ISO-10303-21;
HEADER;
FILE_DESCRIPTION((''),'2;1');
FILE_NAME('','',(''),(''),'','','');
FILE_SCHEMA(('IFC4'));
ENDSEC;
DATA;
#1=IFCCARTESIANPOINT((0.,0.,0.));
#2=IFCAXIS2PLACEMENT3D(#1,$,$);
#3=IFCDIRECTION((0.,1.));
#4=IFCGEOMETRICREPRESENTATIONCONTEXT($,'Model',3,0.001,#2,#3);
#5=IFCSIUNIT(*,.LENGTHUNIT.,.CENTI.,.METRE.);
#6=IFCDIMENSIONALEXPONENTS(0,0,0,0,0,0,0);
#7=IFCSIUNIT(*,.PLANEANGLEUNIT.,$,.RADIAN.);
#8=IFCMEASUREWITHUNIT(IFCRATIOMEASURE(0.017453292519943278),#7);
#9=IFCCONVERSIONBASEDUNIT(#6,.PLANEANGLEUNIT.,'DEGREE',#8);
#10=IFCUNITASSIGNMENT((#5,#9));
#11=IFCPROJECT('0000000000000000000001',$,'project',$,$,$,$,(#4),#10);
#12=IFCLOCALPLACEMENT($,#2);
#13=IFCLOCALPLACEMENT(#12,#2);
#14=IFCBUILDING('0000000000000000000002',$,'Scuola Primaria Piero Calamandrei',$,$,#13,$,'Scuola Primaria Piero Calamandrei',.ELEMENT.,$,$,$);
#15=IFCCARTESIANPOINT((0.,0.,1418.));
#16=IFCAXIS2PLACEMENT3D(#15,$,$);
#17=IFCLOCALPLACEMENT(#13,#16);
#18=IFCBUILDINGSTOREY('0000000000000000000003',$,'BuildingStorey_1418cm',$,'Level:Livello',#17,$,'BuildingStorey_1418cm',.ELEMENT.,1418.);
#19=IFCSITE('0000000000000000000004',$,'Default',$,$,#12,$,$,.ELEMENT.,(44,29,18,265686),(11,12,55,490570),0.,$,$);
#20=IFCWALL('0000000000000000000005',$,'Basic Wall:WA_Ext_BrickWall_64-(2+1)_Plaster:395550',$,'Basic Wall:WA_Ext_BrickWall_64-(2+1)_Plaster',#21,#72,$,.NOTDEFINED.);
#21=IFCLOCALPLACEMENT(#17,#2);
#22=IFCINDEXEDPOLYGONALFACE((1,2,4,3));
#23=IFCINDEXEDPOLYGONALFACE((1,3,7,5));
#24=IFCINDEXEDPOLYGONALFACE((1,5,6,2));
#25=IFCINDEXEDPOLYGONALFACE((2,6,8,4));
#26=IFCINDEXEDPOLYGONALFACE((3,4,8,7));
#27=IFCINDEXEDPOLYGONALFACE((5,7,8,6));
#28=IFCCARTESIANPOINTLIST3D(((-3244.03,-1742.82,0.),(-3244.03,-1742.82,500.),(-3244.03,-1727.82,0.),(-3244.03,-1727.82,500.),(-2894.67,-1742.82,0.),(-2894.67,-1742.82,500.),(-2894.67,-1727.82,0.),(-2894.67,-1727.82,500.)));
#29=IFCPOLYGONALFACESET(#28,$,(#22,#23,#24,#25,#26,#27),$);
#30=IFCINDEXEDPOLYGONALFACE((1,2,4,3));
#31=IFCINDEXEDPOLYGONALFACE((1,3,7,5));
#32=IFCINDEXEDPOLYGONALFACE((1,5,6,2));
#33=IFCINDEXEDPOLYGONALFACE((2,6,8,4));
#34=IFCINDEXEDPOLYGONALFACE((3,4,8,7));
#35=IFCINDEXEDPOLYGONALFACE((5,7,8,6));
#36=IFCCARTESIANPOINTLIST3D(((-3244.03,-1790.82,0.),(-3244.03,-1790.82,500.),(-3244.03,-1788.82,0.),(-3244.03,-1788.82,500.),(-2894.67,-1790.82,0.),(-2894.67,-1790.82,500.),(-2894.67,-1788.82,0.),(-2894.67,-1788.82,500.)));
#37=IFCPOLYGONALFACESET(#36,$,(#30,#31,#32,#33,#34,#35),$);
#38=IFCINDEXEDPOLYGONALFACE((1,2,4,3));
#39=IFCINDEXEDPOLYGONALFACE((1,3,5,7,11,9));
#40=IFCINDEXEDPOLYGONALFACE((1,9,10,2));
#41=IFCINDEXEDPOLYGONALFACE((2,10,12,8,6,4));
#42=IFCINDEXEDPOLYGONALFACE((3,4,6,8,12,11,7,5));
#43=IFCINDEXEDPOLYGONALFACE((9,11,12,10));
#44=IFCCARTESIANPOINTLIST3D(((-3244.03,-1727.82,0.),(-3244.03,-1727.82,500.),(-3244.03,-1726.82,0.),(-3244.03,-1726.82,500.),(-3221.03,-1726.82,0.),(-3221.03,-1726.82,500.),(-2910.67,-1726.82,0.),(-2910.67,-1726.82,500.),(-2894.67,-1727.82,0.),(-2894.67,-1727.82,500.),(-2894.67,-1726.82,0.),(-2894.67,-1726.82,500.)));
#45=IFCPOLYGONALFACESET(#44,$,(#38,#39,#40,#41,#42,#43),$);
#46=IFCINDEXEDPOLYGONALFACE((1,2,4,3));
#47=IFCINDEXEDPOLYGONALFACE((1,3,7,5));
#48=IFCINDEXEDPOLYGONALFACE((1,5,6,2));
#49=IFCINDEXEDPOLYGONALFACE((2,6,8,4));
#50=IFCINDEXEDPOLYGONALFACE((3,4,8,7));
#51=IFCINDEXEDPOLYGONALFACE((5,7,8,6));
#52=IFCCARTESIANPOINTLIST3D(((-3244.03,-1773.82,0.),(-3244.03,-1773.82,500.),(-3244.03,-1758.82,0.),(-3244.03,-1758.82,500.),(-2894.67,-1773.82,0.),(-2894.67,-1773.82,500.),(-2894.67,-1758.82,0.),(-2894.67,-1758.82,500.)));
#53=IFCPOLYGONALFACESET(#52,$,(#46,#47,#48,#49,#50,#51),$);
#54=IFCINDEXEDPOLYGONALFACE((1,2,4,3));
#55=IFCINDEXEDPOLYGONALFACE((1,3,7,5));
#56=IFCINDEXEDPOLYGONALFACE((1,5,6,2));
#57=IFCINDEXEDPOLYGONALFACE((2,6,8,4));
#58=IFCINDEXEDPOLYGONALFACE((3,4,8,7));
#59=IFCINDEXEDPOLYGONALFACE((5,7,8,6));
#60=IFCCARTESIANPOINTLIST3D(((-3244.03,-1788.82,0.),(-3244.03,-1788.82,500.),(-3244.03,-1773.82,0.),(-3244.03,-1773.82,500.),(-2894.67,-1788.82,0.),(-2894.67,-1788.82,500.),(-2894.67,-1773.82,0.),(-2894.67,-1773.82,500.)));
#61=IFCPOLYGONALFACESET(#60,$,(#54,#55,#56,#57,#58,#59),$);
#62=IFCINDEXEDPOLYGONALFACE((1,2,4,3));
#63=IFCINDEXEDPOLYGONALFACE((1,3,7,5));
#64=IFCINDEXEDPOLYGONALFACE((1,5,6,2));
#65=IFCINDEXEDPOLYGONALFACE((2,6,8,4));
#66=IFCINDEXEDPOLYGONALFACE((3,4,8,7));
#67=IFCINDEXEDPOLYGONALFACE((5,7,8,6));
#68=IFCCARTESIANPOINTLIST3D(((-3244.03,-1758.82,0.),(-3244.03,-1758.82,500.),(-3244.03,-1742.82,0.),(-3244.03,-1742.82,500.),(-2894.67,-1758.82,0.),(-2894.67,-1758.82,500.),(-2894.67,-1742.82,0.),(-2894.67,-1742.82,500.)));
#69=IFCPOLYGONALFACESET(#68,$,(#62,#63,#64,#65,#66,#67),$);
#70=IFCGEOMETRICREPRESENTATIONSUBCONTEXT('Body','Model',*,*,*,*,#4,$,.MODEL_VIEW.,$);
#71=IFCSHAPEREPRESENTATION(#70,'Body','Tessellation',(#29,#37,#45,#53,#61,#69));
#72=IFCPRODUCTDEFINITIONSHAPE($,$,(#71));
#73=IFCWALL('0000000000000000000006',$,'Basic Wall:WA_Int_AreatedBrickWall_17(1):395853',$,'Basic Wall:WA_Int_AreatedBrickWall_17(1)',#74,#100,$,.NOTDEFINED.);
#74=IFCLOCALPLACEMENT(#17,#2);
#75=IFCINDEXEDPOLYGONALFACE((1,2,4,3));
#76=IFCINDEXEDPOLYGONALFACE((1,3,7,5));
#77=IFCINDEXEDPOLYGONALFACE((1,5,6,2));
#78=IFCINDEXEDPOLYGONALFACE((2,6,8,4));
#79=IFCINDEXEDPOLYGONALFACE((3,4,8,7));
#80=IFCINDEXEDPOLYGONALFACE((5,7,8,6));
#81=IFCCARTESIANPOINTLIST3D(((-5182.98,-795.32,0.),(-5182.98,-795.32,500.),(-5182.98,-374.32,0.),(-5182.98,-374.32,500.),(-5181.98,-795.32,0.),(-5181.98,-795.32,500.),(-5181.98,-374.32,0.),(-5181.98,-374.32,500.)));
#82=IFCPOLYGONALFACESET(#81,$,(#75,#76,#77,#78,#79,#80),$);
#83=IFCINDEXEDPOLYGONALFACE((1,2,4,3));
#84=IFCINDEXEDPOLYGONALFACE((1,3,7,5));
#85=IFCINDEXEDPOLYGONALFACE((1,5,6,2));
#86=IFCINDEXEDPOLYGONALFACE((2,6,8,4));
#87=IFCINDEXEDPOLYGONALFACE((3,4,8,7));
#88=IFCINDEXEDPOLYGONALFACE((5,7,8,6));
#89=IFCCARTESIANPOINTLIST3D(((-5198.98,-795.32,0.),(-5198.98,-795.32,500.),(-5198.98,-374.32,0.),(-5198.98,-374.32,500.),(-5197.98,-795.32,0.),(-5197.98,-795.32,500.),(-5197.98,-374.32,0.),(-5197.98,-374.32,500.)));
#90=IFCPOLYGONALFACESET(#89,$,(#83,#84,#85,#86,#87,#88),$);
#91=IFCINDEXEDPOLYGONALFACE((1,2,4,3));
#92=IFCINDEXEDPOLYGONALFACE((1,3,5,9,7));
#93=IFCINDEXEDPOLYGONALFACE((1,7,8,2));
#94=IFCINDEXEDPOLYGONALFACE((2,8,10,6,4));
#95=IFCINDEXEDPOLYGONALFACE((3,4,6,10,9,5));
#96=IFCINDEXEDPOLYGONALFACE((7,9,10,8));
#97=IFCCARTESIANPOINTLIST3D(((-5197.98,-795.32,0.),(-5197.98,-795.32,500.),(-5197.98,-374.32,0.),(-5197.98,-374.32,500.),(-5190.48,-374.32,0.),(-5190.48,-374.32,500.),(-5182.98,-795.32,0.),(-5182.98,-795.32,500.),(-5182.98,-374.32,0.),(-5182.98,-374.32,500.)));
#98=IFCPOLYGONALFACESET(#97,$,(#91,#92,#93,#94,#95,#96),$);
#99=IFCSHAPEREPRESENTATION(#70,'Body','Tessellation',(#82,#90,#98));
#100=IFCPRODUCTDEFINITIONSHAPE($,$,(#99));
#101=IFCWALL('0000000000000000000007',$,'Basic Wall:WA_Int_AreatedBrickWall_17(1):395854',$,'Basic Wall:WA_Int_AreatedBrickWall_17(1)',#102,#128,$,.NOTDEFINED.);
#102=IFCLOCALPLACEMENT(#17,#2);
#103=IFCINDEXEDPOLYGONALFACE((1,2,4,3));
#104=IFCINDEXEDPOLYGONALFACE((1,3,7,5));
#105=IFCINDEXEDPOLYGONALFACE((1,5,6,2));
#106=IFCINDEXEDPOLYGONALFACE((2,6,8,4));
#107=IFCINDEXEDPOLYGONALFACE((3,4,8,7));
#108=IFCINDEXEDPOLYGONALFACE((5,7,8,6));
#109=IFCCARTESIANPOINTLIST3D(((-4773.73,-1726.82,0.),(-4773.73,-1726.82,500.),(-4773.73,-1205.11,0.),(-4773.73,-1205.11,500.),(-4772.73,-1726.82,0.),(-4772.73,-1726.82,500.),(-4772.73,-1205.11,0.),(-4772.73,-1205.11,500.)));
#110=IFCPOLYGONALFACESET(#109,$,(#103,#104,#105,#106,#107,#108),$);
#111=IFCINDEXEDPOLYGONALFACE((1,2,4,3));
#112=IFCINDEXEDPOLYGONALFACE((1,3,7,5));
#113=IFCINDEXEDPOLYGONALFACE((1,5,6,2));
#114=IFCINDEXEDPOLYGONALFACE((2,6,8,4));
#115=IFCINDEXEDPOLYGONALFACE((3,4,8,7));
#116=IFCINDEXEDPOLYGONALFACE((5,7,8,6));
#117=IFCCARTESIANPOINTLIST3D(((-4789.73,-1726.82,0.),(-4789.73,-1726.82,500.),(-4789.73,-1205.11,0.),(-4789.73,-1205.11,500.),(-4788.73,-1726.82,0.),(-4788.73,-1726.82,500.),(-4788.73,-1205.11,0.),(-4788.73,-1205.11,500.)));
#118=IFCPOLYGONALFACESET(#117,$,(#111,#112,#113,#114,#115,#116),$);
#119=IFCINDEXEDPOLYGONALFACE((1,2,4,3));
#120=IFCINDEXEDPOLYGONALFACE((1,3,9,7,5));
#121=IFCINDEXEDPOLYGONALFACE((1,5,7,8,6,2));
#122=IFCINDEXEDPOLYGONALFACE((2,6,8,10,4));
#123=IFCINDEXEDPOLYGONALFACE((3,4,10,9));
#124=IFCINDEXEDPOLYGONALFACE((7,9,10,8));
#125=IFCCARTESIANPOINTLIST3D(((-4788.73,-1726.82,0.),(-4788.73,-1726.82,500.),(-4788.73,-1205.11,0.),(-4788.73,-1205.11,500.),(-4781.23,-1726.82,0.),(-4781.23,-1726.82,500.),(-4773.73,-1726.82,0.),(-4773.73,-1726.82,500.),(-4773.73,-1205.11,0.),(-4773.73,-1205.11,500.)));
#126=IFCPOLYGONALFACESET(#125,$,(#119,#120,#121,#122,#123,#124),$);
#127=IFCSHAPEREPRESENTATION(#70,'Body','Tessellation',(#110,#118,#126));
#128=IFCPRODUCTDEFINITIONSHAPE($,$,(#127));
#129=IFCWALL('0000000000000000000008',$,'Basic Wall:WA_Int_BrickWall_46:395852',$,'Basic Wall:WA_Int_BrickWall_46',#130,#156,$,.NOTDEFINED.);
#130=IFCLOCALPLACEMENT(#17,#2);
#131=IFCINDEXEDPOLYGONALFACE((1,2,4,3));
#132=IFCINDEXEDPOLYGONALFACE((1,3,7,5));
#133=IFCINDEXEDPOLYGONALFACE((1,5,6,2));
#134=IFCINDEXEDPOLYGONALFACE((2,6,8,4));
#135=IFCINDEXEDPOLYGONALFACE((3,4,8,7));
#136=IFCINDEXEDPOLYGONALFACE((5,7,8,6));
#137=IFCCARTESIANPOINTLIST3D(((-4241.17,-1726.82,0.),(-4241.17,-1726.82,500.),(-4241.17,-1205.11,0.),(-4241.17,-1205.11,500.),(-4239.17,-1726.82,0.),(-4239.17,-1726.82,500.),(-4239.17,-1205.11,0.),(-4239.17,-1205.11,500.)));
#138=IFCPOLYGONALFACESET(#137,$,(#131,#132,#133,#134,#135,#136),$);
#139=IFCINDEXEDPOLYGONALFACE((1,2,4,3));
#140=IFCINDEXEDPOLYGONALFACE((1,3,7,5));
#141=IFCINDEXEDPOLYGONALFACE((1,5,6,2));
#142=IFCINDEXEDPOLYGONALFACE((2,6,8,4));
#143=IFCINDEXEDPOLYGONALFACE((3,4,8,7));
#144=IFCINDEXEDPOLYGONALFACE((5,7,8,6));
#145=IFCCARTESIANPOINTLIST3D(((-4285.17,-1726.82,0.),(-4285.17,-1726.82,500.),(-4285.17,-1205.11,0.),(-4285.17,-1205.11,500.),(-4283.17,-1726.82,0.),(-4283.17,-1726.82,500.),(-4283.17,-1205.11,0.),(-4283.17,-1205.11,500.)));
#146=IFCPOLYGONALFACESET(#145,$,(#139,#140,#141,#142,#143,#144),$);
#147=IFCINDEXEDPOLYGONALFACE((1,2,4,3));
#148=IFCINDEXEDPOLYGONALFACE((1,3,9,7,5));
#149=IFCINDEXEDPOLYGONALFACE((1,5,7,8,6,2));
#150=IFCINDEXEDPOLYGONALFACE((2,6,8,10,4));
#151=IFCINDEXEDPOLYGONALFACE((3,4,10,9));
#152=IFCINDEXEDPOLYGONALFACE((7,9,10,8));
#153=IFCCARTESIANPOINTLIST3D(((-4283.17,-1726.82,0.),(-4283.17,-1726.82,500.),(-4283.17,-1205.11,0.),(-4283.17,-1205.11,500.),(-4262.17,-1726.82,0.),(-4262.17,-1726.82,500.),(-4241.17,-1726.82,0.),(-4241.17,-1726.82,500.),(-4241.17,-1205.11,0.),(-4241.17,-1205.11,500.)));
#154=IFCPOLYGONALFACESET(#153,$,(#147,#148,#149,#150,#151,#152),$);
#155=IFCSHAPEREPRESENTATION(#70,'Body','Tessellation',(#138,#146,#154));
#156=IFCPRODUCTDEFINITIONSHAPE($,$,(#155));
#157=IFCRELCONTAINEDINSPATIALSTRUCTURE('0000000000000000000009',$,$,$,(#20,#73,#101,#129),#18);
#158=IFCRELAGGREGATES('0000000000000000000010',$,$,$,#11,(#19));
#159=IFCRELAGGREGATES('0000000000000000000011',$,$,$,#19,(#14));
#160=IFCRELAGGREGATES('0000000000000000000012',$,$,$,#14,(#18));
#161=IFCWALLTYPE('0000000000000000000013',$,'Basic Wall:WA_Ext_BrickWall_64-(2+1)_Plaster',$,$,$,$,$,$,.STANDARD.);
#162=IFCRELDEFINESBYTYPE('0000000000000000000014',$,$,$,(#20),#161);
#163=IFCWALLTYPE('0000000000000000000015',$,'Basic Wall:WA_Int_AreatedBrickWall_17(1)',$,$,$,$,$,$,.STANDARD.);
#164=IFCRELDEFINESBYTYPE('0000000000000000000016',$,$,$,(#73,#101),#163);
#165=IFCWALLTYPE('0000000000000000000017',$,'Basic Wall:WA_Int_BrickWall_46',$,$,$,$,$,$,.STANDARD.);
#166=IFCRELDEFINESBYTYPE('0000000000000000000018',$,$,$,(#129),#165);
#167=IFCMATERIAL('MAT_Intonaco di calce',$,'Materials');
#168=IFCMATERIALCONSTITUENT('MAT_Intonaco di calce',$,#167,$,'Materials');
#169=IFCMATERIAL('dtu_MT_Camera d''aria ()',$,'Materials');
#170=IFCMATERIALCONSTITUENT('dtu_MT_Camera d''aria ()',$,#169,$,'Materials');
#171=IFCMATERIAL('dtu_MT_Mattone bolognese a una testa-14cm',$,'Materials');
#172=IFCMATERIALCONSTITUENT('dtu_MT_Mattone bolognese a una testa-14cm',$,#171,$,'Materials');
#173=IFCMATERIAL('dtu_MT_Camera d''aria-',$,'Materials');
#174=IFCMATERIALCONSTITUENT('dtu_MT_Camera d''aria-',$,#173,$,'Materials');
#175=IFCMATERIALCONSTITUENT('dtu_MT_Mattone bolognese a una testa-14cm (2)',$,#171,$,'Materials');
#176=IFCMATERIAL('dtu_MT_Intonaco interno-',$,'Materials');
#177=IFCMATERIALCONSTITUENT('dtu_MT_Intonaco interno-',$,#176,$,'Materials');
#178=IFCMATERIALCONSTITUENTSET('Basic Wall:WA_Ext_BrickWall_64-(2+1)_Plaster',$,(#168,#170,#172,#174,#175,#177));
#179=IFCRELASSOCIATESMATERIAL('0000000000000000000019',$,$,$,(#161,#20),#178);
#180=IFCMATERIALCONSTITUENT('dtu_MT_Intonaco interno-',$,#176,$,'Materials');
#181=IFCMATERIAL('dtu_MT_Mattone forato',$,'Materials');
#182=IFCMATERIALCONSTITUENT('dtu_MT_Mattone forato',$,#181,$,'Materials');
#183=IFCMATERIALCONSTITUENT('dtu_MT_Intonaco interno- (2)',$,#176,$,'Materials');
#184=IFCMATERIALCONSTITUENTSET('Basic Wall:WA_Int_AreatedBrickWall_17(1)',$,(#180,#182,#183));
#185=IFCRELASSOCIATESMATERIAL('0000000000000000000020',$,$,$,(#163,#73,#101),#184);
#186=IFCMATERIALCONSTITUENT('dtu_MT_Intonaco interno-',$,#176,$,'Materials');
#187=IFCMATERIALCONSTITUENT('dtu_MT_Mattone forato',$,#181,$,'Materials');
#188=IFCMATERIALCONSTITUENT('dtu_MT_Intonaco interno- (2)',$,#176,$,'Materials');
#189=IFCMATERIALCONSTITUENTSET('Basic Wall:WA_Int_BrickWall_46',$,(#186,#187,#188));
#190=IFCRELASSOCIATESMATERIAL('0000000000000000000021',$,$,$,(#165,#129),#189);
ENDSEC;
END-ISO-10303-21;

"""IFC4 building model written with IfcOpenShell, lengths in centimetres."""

from ifc_helpers import new_model, entity, si_unit, converted_unit, direction, frame, origin, place, context, subcontext, project, spatial, indexed_curve, outline, extrude, material, constituent, constituent_set, type_object, element, save


model = new_model("IFC4")

# Units and contexts
model_context = context("Model", 3, precision=0.001, world=origin(), true_north=direction((0.0, 1.0)))
body_context = subcontext(model_context, "Body", "Model", "MODEL_VIEW")
ifc_project = project(units=[si_unit("LENGTHUNIT", "METRE", prefix="CENTI"), converted_unit("PLANEANGLEUNIT", "DEGREE", entity("IfcRatioMeasure", 0.017453292519943278), si_unit("PLANEANGLEUNIT", "RADIAN"), dimensions=[0, 0, 0, 0, 0, 0, 0])], contexts=[model_context])

# Site, building, storey
site_placement = place(None, origin())
site = spatial("IfcSite", under=ifc_project, at=site_placement, Name="Default", CompositionType="ELEMENT", RefLatitude=(44, 29, 18, 265686), RefLongitude=(11, 12, 55, 490570), RefElevation=0.0)
building_placement = place(site_placement, origin())
building = spatial("IfcBuilding", under=site, at=building_placement, Name="Scuola Primaria Piero Calamandrei", LongName="Scuola Primaria Piero Calamandrei", CompositionType="ELEMENT")
storey_placement = place(building_placement, frame((0.0, 0.0, 1418.0)))
storey = spatial("IfcBuildingStorey", under=building, at=storey_placement, Name="BuildingStorey_1418cm", ObjectType="Level:Livello", LongName="BuildingStorey_1418cm", CompositionType="ELEMENT", Elevation=1418.0)

# Wall
ifc_material_1 = material(Name="MAT_Intonaco di calce", Category="Materials")
ifc_constituent_1 = constituent(ifc_material_1, Name="MAT_Intonaco di calce", Category="Materials")
ifc_material_2 = material(Name="dtu_MT_Camera d'aria ()", Category="Materials")
ifc_constituent_2 = constituent(ifc_material_2, Name="dtu_MT_Camera d'aria ()", Category="Materials")
ifc_material_3 = material(Name="dtu_MT_Mattone bolognese a una testa-14cm", Category="Materials")
ifc_constituent_3 = constituent(ifc_material_3, Name="dtu_MT_Mattone bolognese a una testa-14cm", Category="Materials")
ifc_material_4 = material(Name="dtu_MT_Camera d'aria-", Category="Materials")
ifc_constituent_4 = constituent(ifc_material_4, Name="dtu_MT_Camera d'aria-", Category="Materials")
ifc_constituent_5 = constituent(ifc_material_3, Name="dtu_MT_Mattone bolognese a una testa-14cm (2)", Category="Materials")
ifc_material_5 = material(Name="dtu_MT_Intonaco interno-", Category="Materials")
ifc_constituent_6 = constituent(ifc_material_5, Name="dtu_MT_Intonaco interno-", Category="Materials")
ifc_constituent_set_1 = constituent_set(constituents=[ifc_constituent_1, ifc_constituent_2, ifc_constituent_3, ifc_constituent_4, ifc_constituent_5, ifc_constituent_6], Name="Basic Wall:WA_Ext_BrickWall_64-(2+1)_Plaster")
wall_type_1 = type_object("IfcWallType", Name="Basic Wall:WA_Ext_BrickWall_64-(2+1)_Plaster", PredefinedType="STANDARD", material=ifc_constituent_set_1)
wall_1_placement = place(storey_placement, frame((-2894.67, -1758.82, 0.0), z_axis=(0.0, 0.0, 1.0), x_axis=(-1.0, 0.0, 0.0)))
element("IfcWall", 1, at=wall_1_placement, inside=storey, type_object=wall_type_1, material=ifc_constituent_set_1, Name="Basic Wall:WA_Ext_BrickWall_64-(2+1)_Plaster:395550", ObjectType="Basic Wall:WA_Ext_BrickWall_64-(2+1)_Plaster", PredefinedType="NOTDEFINED", context=body_context, shape_type="SweptSolid", body=[
    extrude(outline(indexed_curve([(-174.68, -7.5), (174.68, -7.5), (174.68, 7.5), (-174.68, 7.5), (-174.68, -7.5)], self_intersect=False)), frame((174.68, -23.5, 0.0)), (0.0, 0.0, 1.0), 500.0),
    extrude(outline(indexed_curve([(-1.0, -174.68), (1.0, -174.68), (1.0, 174.68), (-1.0, 174.68), (-1.0, -174.68)], self_intersect=False)), frame((174.68, 31.0, 0.0), z_axis=(0.0, 0.0, 1.0), x_axis=(0.0, -1.0, 0.0)), (0.0, 0.0, 1.0), 500.0),
    extrude(outline(indexed_curve([(-157.51, -0.33), (152.85, -0.33), (175.85, -0.33), (175.85, 0.67), (-173.51, 0.67), (-173.51, -0.33), (-157.51, -0.33)], self_intersect=False)), frame((173.51, -31.67, 0.0)), (0.0, 0.0, 1.0), 500.0),
    extrude(outline(indexed_curve([(-174.68, -7.5), (174.68, -7.5), (174.68, 7.5), (-174.68, 7.5), (-174.68, -7.5)], self_intersect=False)), frame((174.68, 7.5, 0.0)), (0.0, 0.0, 1.0), 500.0),
    extrude(outline(indexed_curve([(-174.68, -7.5), (174.68, -7.5), (174.68, 7.5), (-174.68, 7.5), (-174.68, -7.5)], self_intersect=False)), frame((174.68, 22.5, 0.0)), (0.0, 0.0, 1.0), 500.0),
    extrude(outline(indexed_curve([(-174.68, -8.0), (174.68, -8.0), (174.68, 8.0), (-174.68, 8.0), (-174.68, -8.0)], self_intersect=False)), frame((174.68, -8.0, 0.0)), (0.0, 0.0, 1.0), 500.0),
])

# Shared definitions
ifc_constituent_7 = constituent(ifc_material_5, Name="dtu_MT_Intonaco interno-", Category="Materials")
ifc_material_6 = material(Name="dtu_MT_Mattone forato", Category="Materials")
ifc_constituent_8 = constituent(ifc_material_6, Name="dtu_MT_Mattone forato", Category="Materials")
ifc_constituent_9 = constituent(ifc_material_5, Name="dtu_MT_Intonaco interno- (2)", Category="Materials")
ifc_constituent_set_2 = constituent_set(constituents=[ifc_constituent_7, ifc_constituent_8, ifc_constituent_9], Name="Basic Wall:WA_Int_AreatedBrickWall_17(1)")
wall_type_2 = type_object("IfcWallType", Name="Basic Wall:WA_Int_AreatedBrickWall_17(1)", PredefinedType="STANDARD", material=ifc_constituent_set_2)

# Walls
wall_2_placement = place(storey_placement, frame((-5190.48, -795.32, 0.0), z_axis=(0.0, 0.0, 1.0), x_axis=(0.0, 1.0, 0.0)))
element("IfcWall", 2, at=wall_2_placement, inside=storey, type_object=wall_type_2, material=ifc_constituent_set_2, Name="Basic Wall:WA_Int_AreatedBrickWall_17(1):395853", ObjectType="Basic Wall:WA_Int_AreatedBrickWall_17(1)", PredefinedType="NOTDEFINED", context=body_context, shape_type="SweptSolid", body=[
    extrude(outline(indexed_curve([(-0.5, -210.5), (0.5, -210.5), (0.5, 210.5), (-0.5, 210.5), (-0.5, -210.5)], self_intersect=False)), frame((210.5, -8.0, 0.0), z_axis=(0.0, 0.0, 1.0), x_axis=(0.0, 1.0, 0.0)), (0.0, 0.0, 1.0), 500.0),
    extrude(outline(indexed_curve([(-0.5, -210.5), (0.5, -210.5), (0.5, 210.5), (-0.5, 210.5), (-0.5, -210.5)], self_intersect=False)), frame((210.5, 8.0, 0.0), z_axis=(0.0, 0.0, 1.0), x_axis=(0.0, -1.0, 0.0)), (0.0, 0.0, 1.0), 500.0),
    extrude(outline(indexed_curve([(-252.6, -7.5), (168.4, -7.5), (168.4, 0.0), (168.4, 7.5), (-252.6, 7.5), (-252.6, -7.5)], self_intersect=False)), frame((252.6, 0.0, 0.0)), (0.0, 0.0, 1.0), 500.0),
])
wall_3_placement = place(storey_placement, frame((-4781.23, -1726.82, 0.0), z_axis=(0.0, 0.0, 1.0), x_axis=(0.0, 1.0, 0.0)))
element("IfcWall", 3, at=wall_3_placement, inside=storey, type_object=wall_type_2, material=ifc_constituent_set_2, Name="Basic Wall:WA_Int_AreatedBrickWall_17(1):395854", ObjectType="Basic Wall:WA_Int_AreatedBrickWall_17(1)", PredefinedType="NOTDEFINED", context=body_context, shape_type="SweptSolid", body=[
    extrude(outline(indexed_curve([(-0.5, -260.86), (0.5, -260.86), (0.5, 260.86), (-0.5, 260.86), (-0.5, -260.86)], self_intersect=False)), frame((260.86, -8.0, 0.0), z_axis=(0.0, 0.0, 1.0), x_axis=(0.0, 1.0, 0.0)), (0.0, 0.0, 1.0), 500.0),
    extrude(outline(indexed_curve([(-0.5, -260.86), (0.5, -260.86), (0.5, 260.86), (-0.5, 260.86), (-0.5, -260.86)], self_intersect=False)), frame((260.86, 8.0, 0.0), z_axis=(0.0, 0.0, 1.0), x_axis=(0.0, -1.0, 0.0)), (0.0, 0.0, 1.0), 500.0),
    extrude(outline(indexed_curve([(-208.69, -7.5), (313.03, -7.5), (313.03, 7.5), (-208.69, 7.5), (-208.69, 0.0), (-208.69, -7.5)], self_intersect=False)), frame((208.69, 0.0, 0.0)), (0.0, 0.0, 1.0), 500.0),
])

# Shared definitions
ifc_constituent_10 = constituent(ifc_material_5, Name="dtu_MT_Intonaco interno-", Category="Materials")
ifc_constituent_11 = constituent(ifc_material_6, Name="dtu_MT_Mattone forato", Category="Materials")
ifc_constituent_12 = constituent(ifc_material_5, Name="dtu_MT_Intonaco interno- (2)", Category="Materials")
ifc_constituent_set_3 = constituent_set(constituents=[ifc_constituent_10, ifc_constituent_11, ifc_constituent_12], Name="Basic Wall:WA_Int_BrickWall_46")
wall_type_3 = type_object("IfcWallType", Name="Basic Wall:WA_Int_BrickWall_46", PredefinedType="STANDARD", material=ifc_constituent_set_3)

# Wall
wall_4_placement = place(storey_placement, frame((-4262.17, -1726.82, 0.0), z_axis=(0.0, 0.0, 1.0), x_axis=(0.0, 1.0, 0.0)))
element("IfcWall", 4, at=wall_4_placement, inside=storey, type_object=wall_type_3, material=ifc_constituent_set_3, Name="Basic Wall:WA_Int_BrickWall_46:395852", ObjectType="Basic Wall:WA_Int_BrickWall_46", PredefinedType="NOTDEFINED", context=body_context, shape_type="SweptSolid", body=[
    extrude(outline(indexed_curve([(-1.0, -260.86), (1.0, -260.86), (1.0, 260.86), (-1.0, 260.86), (-1.0, -260.86)], self_intersect=False)), frame((260.86, -22.0, 0.0), z_axis=(0.0, 0.0, 1.0), x_axis=(0.0, 1.0, 0.0)), (0.0, 0.0, 1.0), 500.0),
    extrude(outline(indexed_curve([(-1.0, -260.86), (1.0, -260.86), (1.0, 260.86), (-1.0, 260.86), (-1.0, -260.86)], self_intersect=False)), frame((260.86, 22.0, 0.0), z_axis=(0.0, 0.0, 1.0), x_axis=(0.0, -1.0, 0.0)), (0.0, 0.0, 1.0), 500.0),
    extrude(outline(indexed_curve([(-208.69, -21.0), (313.03, -21.0), (313.03, 21.0), (-208.69, 21.0), (-208.69, 0.0), (-208.69, -21.0)], self_intersect=False)), frame((208.69, 0.0, 0.0)), (0.0, 0.0, 1.0), 500.0),
])

save(model, "model.ifc")
